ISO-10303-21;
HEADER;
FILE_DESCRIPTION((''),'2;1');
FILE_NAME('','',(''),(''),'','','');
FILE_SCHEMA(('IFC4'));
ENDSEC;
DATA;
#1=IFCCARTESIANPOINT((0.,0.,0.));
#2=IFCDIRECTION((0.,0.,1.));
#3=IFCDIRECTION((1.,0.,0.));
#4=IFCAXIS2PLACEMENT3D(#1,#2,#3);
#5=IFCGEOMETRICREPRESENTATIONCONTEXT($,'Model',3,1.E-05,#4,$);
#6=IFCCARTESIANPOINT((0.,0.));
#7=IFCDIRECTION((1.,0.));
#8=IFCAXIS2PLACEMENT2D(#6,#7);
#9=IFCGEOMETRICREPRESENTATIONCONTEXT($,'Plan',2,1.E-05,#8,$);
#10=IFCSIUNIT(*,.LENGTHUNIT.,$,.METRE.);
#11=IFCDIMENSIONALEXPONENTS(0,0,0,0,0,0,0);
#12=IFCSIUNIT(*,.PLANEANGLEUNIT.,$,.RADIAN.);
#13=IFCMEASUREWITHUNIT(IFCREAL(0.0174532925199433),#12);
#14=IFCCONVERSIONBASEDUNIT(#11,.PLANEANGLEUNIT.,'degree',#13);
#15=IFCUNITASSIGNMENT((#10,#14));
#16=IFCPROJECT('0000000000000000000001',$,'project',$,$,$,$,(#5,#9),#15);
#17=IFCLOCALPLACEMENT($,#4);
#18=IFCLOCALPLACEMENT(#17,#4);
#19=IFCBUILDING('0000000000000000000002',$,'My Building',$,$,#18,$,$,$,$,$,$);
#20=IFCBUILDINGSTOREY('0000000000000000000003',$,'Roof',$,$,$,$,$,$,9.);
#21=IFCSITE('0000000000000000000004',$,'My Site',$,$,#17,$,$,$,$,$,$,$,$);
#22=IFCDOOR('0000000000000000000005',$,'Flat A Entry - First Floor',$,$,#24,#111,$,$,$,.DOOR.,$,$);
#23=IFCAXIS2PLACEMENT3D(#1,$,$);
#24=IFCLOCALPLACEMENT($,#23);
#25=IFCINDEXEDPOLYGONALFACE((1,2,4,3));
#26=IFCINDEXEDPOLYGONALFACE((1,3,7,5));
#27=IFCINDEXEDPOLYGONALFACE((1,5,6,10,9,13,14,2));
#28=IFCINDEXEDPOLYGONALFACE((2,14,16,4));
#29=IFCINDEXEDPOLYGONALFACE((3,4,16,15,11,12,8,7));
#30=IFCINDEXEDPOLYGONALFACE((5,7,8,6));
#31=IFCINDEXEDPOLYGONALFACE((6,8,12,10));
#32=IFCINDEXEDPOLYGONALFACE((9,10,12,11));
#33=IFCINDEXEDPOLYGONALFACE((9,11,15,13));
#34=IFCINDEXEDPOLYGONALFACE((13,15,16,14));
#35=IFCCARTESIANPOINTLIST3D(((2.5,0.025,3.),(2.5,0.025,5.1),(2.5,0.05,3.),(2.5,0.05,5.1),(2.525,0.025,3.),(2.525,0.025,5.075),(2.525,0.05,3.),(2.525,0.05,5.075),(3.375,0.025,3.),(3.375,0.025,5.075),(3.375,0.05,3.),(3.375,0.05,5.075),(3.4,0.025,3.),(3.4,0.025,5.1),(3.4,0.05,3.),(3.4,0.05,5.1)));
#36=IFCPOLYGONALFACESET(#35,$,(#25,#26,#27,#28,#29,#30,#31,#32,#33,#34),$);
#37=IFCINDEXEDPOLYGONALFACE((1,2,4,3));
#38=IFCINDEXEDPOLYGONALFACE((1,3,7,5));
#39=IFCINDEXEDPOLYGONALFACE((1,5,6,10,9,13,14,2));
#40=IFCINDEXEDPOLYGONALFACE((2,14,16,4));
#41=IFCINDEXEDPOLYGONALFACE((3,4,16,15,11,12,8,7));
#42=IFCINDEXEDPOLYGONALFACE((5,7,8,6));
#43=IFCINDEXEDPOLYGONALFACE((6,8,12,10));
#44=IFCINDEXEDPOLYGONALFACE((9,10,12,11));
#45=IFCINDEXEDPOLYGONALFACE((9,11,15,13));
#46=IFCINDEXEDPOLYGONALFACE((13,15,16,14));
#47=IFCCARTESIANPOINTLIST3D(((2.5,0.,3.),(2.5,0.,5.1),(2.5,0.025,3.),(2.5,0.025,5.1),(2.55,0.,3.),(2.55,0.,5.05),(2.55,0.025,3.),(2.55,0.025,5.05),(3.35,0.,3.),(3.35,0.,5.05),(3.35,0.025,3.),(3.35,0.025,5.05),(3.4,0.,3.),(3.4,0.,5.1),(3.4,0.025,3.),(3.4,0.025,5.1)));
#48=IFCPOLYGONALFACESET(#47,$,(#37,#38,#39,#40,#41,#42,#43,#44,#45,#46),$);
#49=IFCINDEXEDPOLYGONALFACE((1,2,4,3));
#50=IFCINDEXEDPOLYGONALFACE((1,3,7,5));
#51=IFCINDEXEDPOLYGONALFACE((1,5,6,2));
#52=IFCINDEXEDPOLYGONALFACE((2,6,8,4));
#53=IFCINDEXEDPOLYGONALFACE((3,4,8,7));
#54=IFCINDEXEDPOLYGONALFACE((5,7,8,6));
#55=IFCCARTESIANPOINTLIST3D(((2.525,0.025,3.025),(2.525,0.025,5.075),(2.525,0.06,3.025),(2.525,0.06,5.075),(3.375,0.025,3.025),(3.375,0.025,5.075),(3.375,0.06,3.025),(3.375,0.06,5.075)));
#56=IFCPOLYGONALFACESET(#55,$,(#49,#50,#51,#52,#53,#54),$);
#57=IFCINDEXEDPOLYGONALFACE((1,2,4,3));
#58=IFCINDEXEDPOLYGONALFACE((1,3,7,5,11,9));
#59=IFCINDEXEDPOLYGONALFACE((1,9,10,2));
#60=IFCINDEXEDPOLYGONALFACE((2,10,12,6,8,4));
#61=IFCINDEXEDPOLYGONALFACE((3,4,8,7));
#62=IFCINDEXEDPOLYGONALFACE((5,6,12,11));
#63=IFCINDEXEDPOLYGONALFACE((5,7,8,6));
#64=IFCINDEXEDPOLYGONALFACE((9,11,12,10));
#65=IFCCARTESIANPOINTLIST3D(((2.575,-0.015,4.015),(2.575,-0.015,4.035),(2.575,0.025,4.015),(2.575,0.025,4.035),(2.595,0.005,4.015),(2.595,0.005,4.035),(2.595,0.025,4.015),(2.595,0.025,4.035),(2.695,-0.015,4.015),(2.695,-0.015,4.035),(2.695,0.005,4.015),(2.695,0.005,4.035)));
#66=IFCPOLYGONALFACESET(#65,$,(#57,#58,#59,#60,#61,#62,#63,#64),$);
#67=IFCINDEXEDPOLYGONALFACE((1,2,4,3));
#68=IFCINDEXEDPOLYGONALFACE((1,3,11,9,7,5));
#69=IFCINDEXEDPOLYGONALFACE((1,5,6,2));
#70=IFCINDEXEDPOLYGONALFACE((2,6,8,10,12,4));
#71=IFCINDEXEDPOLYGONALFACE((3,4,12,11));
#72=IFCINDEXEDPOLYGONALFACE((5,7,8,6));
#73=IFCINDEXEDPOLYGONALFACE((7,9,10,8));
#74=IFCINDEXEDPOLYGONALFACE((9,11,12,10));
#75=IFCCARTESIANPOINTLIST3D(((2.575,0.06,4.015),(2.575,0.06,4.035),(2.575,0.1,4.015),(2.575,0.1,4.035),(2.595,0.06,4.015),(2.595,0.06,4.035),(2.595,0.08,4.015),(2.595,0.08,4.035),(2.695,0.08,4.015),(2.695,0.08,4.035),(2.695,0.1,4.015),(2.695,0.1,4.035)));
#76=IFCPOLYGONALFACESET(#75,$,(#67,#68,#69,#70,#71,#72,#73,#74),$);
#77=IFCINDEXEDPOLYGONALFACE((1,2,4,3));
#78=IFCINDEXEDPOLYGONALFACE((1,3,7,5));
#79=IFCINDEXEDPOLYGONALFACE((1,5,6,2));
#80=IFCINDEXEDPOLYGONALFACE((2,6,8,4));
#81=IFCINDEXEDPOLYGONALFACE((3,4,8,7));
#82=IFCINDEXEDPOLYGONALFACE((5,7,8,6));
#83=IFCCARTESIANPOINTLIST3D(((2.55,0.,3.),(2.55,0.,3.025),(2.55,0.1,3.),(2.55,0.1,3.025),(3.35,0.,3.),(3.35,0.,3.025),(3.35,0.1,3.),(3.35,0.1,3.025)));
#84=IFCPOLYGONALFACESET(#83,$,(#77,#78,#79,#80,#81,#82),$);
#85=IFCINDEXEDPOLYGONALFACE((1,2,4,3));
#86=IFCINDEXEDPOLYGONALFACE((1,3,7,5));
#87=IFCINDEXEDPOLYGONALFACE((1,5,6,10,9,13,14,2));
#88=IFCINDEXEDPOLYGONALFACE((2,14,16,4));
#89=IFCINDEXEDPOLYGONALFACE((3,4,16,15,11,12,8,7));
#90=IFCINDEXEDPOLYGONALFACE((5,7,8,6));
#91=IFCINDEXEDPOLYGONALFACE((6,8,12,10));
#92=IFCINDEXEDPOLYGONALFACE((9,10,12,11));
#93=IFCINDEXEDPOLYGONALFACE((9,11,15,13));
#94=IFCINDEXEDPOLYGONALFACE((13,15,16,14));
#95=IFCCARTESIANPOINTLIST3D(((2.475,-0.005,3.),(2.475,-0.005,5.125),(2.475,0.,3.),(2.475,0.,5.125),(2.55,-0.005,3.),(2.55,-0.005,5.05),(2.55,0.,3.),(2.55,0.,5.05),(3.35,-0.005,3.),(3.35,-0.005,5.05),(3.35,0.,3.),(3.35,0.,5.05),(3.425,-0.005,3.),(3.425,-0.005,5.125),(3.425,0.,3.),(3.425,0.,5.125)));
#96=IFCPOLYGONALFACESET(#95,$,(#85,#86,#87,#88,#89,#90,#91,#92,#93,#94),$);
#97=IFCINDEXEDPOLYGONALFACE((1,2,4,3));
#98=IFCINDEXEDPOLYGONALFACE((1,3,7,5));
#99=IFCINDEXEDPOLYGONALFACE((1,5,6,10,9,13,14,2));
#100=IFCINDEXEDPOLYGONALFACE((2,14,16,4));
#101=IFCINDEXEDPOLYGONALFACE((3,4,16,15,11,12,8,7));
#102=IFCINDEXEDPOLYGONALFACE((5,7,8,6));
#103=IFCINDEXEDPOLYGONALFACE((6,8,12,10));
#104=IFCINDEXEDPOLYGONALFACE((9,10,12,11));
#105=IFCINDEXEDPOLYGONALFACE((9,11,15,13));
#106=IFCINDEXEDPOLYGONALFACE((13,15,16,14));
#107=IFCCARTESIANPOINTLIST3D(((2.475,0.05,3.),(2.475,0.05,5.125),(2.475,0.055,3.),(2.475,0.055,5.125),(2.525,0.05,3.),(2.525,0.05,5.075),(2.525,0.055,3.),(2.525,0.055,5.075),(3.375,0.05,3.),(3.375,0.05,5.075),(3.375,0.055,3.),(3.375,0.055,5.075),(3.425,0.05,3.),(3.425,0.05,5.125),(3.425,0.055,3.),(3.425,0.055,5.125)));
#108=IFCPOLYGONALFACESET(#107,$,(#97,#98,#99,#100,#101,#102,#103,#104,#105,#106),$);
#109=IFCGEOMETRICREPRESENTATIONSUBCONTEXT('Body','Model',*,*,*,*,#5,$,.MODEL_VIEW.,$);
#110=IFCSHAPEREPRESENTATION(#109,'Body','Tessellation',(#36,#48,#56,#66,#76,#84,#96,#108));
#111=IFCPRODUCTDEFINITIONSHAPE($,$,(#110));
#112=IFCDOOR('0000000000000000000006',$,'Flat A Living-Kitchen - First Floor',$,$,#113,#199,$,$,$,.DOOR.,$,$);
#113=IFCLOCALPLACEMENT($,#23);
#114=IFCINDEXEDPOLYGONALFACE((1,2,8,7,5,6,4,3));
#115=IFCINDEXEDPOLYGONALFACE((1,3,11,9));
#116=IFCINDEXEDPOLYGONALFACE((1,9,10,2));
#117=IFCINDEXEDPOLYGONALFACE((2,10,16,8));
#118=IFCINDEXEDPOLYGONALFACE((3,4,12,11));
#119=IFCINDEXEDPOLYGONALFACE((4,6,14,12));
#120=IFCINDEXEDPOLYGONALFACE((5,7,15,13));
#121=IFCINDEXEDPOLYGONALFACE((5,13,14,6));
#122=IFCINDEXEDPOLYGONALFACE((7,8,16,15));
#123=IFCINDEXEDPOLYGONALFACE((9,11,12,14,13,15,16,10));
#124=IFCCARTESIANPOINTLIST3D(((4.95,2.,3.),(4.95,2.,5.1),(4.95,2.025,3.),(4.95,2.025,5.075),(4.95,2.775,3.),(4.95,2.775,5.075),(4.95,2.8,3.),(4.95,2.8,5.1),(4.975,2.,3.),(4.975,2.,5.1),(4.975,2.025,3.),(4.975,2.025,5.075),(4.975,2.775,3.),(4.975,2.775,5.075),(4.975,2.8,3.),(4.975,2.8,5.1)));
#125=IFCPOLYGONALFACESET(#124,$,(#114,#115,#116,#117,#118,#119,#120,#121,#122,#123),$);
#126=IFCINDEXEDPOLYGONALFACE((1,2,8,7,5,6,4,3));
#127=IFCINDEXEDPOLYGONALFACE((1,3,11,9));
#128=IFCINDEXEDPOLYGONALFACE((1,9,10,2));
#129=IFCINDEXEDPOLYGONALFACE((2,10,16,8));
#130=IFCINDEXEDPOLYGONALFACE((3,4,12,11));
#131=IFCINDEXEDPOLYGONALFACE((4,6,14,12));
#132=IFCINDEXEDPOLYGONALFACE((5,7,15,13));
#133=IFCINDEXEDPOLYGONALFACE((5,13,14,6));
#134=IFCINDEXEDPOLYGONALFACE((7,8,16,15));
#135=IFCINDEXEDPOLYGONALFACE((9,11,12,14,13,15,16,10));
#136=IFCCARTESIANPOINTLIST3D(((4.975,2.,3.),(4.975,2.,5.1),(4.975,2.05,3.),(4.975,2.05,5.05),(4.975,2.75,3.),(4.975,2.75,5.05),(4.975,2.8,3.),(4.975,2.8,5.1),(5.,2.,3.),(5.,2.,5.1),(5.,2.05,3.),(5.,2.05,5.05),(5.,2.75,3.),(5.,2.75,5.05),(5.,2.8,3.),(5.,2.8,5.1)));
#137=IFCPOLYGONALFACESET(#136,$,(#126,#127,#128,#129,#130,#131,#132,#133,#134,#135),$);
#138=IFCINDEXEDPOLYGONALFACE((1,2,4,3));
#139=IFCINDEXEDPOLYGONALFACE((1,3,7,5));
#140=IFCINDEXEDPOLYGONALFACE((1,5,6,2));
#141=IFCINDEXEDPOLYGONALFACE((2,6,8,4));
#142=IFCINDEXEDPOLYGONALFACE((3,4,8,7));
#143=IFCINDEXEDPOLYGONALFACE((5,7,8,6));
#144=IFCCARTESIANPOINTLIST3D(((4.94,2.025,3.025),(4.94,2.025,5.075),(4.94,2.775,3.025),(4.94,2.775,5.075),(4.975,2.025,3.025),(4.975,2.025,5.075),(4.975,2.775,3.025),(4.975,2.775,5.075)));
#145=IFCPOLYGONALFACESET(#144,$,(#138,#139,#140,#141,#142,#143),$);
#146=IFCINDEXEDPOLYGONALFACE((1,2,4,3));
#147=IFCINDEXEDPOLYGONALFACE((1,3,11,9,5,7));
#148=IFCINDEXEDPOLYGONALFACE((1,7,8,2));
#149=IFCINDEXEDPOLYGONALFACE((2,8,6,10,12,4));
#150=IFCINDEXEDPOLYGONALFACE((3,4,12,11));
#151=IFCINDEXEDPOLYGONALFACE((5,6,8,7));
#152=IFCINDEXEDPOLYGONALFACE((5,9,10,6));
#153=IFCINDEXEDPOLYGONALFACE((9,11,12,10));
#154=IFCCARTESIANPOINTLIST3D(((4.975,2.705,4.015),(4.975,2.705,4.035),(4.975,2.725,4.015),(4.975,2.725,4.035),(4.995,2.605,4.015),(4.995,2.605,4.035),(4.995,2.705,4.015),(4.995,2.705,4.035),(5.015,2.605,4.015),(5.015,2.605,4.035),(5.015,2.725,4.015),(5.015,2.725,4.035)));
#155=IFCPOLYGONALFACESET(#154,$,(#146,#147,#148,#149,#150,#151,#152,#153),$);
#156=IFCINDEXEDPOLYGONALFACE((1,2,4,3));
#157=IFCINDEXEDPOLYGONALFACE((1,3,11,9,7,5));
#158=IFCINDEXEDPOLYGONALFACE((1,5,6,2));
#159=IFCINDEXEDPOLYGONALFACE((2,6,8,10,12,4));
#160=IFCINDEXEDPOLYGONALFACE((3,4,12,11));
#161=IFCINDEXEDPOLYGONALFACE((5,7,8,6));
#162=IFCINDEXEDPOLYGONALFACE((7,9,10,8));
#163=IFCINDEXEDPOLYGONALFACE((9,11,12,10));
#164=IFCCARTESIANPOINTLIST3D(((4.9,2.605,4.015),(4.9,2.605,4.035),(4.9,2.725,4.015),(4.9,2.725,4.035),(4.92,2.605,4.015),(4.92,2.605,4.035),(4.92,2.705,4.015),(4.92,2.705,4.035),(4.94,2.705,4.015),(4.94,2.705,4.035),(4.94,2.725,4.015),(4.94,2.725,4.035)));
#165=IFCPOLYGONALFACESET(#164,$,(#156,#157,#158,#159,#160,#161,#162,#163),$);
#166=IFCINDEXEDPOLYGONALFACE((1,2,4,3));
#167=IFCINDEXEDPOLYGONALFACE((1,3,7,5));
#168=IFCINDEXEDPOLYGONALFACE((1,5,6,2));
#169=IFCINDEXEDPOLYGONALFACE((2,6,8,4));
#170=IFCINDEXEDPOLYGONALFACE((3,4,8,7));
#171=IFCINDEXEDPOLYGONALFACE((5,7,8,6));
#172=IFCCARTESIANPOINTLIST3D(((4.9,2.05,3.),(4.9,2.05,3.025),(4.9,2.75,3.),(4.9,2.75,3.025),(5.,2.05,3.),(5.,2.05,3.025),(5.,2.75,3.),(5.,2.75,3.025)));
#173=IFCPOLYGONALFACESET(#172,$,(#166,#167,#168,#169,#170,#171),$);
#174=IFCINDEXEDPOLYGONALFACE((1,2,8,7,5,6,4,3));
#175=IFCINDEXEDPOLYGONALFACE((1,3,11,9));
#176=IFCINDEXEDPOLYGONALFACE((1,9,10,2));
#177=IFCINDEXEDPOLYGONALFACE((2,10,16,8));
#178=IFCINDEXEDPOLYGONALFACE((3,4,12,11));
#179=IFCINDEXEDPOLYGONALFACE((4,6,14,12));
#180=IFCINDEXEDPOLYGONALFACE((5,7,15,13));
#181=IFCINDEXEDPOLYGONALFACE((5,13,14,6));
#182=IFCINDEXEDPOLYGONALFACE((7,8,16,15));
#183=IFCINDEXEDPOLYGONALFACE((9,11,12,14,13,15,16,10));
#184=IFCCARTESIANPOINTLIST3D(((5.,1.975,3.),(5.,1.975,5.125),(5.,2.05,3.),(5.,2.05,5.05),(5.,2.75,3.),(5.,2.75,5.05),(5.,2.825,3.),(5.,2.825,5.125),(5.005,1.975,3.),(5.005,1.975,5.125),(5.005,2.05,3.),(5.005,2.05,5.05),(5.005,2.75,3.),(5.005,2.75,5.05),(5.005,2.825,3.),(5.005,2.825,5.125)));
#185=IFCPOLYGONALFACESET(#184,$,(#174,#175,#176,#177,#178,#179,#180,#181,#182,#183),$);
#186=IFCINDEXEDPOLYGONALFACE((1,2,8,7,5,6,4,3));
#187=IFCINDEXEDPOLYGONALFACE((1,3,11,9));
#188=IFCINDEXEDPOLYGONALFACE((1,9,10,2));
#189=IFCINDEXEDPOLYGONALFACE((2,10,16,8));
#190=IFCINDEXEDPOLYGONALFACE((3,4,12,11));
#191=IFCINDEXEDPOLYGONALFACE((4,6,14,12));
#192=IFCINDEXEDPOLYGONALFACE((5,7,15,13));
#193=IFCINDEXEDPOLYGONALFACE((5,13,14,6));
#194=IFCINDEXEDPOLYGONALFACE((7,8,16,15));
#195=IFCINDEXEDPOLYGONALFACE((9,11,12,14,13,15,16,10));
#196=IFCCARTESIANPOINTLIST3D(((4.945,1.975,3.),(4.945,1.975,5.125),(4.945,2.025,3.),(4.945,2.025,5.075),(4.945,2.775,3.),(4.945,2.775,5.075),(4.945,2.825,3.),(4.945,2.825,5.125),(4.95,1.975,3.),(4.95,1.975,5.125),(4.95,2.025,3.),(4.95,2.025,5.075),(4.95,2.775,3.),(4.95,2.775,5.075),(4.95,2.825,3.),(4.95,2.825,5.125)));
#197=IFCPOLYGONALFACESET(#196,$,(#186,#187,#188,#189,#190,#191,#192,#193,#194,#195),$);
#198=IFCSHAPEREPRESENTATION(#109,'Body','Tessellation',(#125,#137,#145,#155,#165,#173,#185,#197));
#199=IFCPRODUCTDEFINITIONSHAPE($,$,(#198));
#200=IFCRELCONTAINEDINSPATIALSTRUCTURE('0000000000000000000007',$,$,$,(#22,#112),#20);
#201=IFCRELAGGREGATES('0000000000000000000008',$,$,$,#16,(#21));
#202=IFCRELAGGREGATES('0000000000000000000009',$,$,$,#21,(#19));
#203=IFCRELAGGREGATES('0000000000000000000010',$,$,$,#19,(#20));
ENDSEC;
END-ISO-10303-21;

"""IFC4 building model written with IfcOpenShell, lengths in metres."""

from ifc_helpers import new_model, entity, si_unit, converted_unit, frame, origin_with_axes, origin_2d_with_axis, place, context, subcontext, project, spatial, line, indexed_curve, outline, extrude, element, save


model = new_model("IFC4")

# Units and contexts
model_context = context("Model", 3, precision=1e-05, world=origin_with_axes())
plan_context = context("Plan", 2, precision=1e-05, world=origin_2d_with_axis())
body_context = subcontext(model_context, "Body", "Model", "MODEL_VIEW")
ifc_project = project(units=[si_unit("LENGTHUNIT", "METRE"), converted_unit("PLANEANGLEUNIT", "degree", entity("IfcReal", 0.0174532925199433), si_unit("PLANEANGLEUNIT", "RADIAN"), dimensions=[0, 0, 0, 0, 0, 0, 0])], contexts=[model_context, plan_context])

# Site, building, storey
site_placement = place(None, origin_with_axes())
site = spatial("IfcSite", under=ifc_project, at=site_placement, Name="My Site")
building_placement = place(site_placement, origin_with_axes())
building = spatial("IfcBuilding", under=site, at=building_placement, Name="My Building")
storey = spatial("IfcBuildingStorey", under=building, Name="Roof", Elevation=9.0)

# Doors
door_1_placement = place(None, frame((2.5, 0.0, 3.0), z_axis=(0.0, 0.0, 1.0), x_axis=(1.0, 0.0, 0.0)))
element("IfcDoor", 1, at=door_1_placement, inside=storey, Name="Flat A Entry - First Floor", PredefinedType="DOOR", context=body_context, shape_type="SweptSolid", body=[
    extrude(outline(indexed_curve([(0.0, 0.0), (0.0, 2.1), (0.9, 2.1), (0.9, 0.0), (0.875, 0.0), (0.875, 2.075), (0.025, 2.075), (0.025, 0.0)], segments=[line(1, 2, 3, 4, 5, 6, 7, 8, 1)])), frame((0.0, 0.025, 0.0), z_axis=(0.0, -1.0, 0.0), x_axis=(1.0, 0.0, 0.0)), (0.0, 0.0, -1.0), 0.025),
    extrude(outline(indexed_curve([(0.0, 0.0), (0.0, 2.1), (0.9, 2.1), (0.9, 0.0), (0.85, 0.0), (0.85, 2.05), (0.05, 2.05), (0.05, 0.0)], segments=[line(1, 2, 3, 4, 5, 6, 7, 8, 1)])), frame((0.0, 0.0, 0.0), z_axis=(0.0, -1.0, 0.0), x_axis=(1.0, 0.0, 0.0)), (0.0, 0.0, -1.0), 0.025),
    extrude(outline(indexed_curve([(0.0, 0.0), (0.85, 0.0), (0.85, 0.035), (0.0, 0.035)], segments=[line(1, 2, 3, 4, 1)])), frame((0.025, 0.025, 0.025), z_axis=(0.0, 0.0, 1.0), x_axis=(1.0, 0.0, 0.0)), (0.0, 0.0, 1.0), 2.05),
    extrude(outline(indexed_curve([(0.0, 0.0), (0.0, -0.04), (0.12, -0.04), (0.12, -0.02), (0.02, -0.02), (0.02, 0.0)], segments=[line(1, 2, 3, 4, 5, 6, 1)])), frame((0.075, 0.025, 1.015), z_axis=(0.0, 0.0, 1.0), x_axis=(1.0, 0.0, 0.0)), (0.0, 0.0, 1.0), 0.02),
    extrude(outline(indexed_curve([(0.0, 0.0), (0.0, 0.04), (0.12, 0.04), (0.12, 0.02), (0.02, 0.02), (0.02, 0.0)], segments=[line(1, 2, 3, 4, 5, 6, 1)])), frame((0.075, 0.06, 1.015), z_axis=(0.0, 0.0, 1.0), x_axis=(1.0, 0.0, 0.0)), (0.0, 0.0, 1.0), 0.02),
    extrude(outline(indexed_curve([(0.0, 0.0), (0.8, 0.0), (0.8, 0.1), (0.0, 0.1)], segments=[line(1, 2, 3, 4, 1)])), frame((0.05, 0.0, 0.0), z_axis=(0.0, 0.0, 1.0), x_axis=(1.0, 0.0, 0.0)), (0.0, 0.0, 1.0), 0.025),
    extrude(outline(indexed_curve([(0.0, 0.0), (0.0, 2.125), (0.95, 2.125), (0.95, 0.0), (0.875, 0.0), (0.875, 2.05), (0.075, 2.05), (0.075, 0.0)], segments=[line(1, 2, 3, 4, 5, 6, 7, 8, 1)])), frame((-0.025, -0.005, 0.0), z_axis=(0.0, -1.0, 0.0), x_axis=(1.0, 0.0, 0.0)), (0.0, 0.0, -1.0), 0.005),
    extrude(outline(indexed_curve([(0.0, 0.0), (0.0, 2.125), (0.95, 2.125), (0.95, 0.0), (0.9, 0.0), (0.9, 2.075), (0.05, 2.075), (0.05, 0.0)], segments=[line(1, 2, 3, 4, 5, 6, 7, 8, 1)])), frame((-0.025, 0.05, 0.0), z_axis=(0.0, -1.0, 0.0), x_axis=(1.0, 0.0, 0.0)), (0.0, 0.0, -1.0), 0.005),
])
door_2_placement = place(None, frame((5.0, 2.0, 3.0), z_axis=(0.0, 0.0, 1.0), x_axis=(0.0, 1.0, 0.0)))
element("IfcDoor", 2, at=door_2_placement, inside=storey, Name="Flat A Living-Kitchen - First Floor", PredefinedType="DOOR", context=body_context, shape_type="SweptSolid", body=[
    extrude(outline(indexed_curve([(0.0, 0.0), (0.0, 2.1), (0.8, 2.1), (0.8, 0.0), (0.775, 0.0), (0.775, 2.075), (0.025, 2.075), (0.025, 0.0)], segments=[line(1, 2, 3, 4, 5, 6, 7, 8, 1)])), frame((0.0, 0.025, 0.0), z_axis=(0.0, -1.0, 0.0), x_axis=(1.0, 0.0, 0.0)), (0.0, 0.0, -1.0), 0.025),
    extrude(outline(indexed_curve([(0.0, 0.0), (0.0, 2.1), (0.8, 2.1), (0.8, 0.0), (0.75, 0.0), (0.75, 2.05), (0.05, 2.05), (0.05, 0.0)], segments=[line(1, 2, 3, 4, 5, 6, 7, 8, 1)])), frame((0.0, 0.0, 0.0), z_axis=(0.0, -1.0, 0.0), x_axis=(1.0, 0.0, 0.0)), (0.0, 0.0, -1.0), 0.025),
    extrude(outline(indexed_curve([(0.0, 0.0), (0.75, 0.0), (0.75, 0.035), (0.0, 0.035)], segments=[line(1, 2, 3, 4, 1)])), frame((0.025, 0.025, 0.025), z_axis=(0.0, 0.0, 1.0), x_axis=(1.0, 0.0, 0.0)), (0.0, 0.0, 1.0), 2.05),
    extrude(outline(indexed_curve([(0.0, 0.0), (0.0, -0.04), (-0.12, -0.04), (-0.12, -0.02), (-0.02, -0.02), (-0.02, 0.0)], segments=[line(1, 2, 3, 4, 5, 6, 1)])), frame((0.725, 0.025, 1.015), z_axis=(0.0, 0.0, 1.0), x_axis=(1.0, 0.0, 0.0)), (0.0, 0.0, 1.0), 0.02),
    extrude(outline(indexed_curve([(0.0, 0.0), (0.0, 0.04), (-0.12, 0.04), (-0.12, 0.02), (-0.02, 0.02), (-0.02, 0.0)], segments=[line(1, 2, 3, 4, 5, 6, 1)])), frame((0.725, 0.06, 1.015), z_axis=(0.0, 0.0, 1.0), x_axis=(1.0, 0.0, 0.0)), (0.0, 0.0, 1.0), 0.02),
    extrude(outline(indexed_curve([(0.0, 0.0), (0.7, 0.0), (0.7, 0.1), (0.0, 0.1)], segments=[line(1, 2, 3, 4, 1)])), frame((0.05, 0.0, 0.0), z_axis=(0.0, 0.0, 1.0), x_axis=(1.0, 0.0, 0.0)), (0.0, 0.0, 1.0), 0.025),
    extrude(outline(indexed_curve([(0.0, 0.0), (0.0, 2.125), (0.85, 2.125), (0.85, 0.0), (0.775, 0.0), (0.775, 2.05), (0.075, 2.05), (0.075, 0.0)], segments=[line(1, 2, 3, 4, 5, 6, 7, 8, 1)])), frame((-0.025, -0.005, 0.0), z_axis=(0.0, -1.0, 0.0), x_axis=(1.0, 0.0, 0.0)), (0.0, 0.0, -1.0), 0.005),
    extrude(outline(indexed_curve([(0.0, 0.0), (0.0, 2.125), (0.85, 2.125), (0.85, 0.0), (0.8, 0.0), (0.8, 2.075), (0.05, 2.075), (0.05, 0.0)], segments=[line(1, 2, 3, 4, 5, 6, 7, 8, 1)])), frame((-0.025, 0.05, 0.0), z_axis=(0.0, -1.0, 0.0), x_axis=(1.0, 0.0, 0.0)), (0.0, 0.0, -1.0), 0.005),
])

save(model, "model.ifc")
